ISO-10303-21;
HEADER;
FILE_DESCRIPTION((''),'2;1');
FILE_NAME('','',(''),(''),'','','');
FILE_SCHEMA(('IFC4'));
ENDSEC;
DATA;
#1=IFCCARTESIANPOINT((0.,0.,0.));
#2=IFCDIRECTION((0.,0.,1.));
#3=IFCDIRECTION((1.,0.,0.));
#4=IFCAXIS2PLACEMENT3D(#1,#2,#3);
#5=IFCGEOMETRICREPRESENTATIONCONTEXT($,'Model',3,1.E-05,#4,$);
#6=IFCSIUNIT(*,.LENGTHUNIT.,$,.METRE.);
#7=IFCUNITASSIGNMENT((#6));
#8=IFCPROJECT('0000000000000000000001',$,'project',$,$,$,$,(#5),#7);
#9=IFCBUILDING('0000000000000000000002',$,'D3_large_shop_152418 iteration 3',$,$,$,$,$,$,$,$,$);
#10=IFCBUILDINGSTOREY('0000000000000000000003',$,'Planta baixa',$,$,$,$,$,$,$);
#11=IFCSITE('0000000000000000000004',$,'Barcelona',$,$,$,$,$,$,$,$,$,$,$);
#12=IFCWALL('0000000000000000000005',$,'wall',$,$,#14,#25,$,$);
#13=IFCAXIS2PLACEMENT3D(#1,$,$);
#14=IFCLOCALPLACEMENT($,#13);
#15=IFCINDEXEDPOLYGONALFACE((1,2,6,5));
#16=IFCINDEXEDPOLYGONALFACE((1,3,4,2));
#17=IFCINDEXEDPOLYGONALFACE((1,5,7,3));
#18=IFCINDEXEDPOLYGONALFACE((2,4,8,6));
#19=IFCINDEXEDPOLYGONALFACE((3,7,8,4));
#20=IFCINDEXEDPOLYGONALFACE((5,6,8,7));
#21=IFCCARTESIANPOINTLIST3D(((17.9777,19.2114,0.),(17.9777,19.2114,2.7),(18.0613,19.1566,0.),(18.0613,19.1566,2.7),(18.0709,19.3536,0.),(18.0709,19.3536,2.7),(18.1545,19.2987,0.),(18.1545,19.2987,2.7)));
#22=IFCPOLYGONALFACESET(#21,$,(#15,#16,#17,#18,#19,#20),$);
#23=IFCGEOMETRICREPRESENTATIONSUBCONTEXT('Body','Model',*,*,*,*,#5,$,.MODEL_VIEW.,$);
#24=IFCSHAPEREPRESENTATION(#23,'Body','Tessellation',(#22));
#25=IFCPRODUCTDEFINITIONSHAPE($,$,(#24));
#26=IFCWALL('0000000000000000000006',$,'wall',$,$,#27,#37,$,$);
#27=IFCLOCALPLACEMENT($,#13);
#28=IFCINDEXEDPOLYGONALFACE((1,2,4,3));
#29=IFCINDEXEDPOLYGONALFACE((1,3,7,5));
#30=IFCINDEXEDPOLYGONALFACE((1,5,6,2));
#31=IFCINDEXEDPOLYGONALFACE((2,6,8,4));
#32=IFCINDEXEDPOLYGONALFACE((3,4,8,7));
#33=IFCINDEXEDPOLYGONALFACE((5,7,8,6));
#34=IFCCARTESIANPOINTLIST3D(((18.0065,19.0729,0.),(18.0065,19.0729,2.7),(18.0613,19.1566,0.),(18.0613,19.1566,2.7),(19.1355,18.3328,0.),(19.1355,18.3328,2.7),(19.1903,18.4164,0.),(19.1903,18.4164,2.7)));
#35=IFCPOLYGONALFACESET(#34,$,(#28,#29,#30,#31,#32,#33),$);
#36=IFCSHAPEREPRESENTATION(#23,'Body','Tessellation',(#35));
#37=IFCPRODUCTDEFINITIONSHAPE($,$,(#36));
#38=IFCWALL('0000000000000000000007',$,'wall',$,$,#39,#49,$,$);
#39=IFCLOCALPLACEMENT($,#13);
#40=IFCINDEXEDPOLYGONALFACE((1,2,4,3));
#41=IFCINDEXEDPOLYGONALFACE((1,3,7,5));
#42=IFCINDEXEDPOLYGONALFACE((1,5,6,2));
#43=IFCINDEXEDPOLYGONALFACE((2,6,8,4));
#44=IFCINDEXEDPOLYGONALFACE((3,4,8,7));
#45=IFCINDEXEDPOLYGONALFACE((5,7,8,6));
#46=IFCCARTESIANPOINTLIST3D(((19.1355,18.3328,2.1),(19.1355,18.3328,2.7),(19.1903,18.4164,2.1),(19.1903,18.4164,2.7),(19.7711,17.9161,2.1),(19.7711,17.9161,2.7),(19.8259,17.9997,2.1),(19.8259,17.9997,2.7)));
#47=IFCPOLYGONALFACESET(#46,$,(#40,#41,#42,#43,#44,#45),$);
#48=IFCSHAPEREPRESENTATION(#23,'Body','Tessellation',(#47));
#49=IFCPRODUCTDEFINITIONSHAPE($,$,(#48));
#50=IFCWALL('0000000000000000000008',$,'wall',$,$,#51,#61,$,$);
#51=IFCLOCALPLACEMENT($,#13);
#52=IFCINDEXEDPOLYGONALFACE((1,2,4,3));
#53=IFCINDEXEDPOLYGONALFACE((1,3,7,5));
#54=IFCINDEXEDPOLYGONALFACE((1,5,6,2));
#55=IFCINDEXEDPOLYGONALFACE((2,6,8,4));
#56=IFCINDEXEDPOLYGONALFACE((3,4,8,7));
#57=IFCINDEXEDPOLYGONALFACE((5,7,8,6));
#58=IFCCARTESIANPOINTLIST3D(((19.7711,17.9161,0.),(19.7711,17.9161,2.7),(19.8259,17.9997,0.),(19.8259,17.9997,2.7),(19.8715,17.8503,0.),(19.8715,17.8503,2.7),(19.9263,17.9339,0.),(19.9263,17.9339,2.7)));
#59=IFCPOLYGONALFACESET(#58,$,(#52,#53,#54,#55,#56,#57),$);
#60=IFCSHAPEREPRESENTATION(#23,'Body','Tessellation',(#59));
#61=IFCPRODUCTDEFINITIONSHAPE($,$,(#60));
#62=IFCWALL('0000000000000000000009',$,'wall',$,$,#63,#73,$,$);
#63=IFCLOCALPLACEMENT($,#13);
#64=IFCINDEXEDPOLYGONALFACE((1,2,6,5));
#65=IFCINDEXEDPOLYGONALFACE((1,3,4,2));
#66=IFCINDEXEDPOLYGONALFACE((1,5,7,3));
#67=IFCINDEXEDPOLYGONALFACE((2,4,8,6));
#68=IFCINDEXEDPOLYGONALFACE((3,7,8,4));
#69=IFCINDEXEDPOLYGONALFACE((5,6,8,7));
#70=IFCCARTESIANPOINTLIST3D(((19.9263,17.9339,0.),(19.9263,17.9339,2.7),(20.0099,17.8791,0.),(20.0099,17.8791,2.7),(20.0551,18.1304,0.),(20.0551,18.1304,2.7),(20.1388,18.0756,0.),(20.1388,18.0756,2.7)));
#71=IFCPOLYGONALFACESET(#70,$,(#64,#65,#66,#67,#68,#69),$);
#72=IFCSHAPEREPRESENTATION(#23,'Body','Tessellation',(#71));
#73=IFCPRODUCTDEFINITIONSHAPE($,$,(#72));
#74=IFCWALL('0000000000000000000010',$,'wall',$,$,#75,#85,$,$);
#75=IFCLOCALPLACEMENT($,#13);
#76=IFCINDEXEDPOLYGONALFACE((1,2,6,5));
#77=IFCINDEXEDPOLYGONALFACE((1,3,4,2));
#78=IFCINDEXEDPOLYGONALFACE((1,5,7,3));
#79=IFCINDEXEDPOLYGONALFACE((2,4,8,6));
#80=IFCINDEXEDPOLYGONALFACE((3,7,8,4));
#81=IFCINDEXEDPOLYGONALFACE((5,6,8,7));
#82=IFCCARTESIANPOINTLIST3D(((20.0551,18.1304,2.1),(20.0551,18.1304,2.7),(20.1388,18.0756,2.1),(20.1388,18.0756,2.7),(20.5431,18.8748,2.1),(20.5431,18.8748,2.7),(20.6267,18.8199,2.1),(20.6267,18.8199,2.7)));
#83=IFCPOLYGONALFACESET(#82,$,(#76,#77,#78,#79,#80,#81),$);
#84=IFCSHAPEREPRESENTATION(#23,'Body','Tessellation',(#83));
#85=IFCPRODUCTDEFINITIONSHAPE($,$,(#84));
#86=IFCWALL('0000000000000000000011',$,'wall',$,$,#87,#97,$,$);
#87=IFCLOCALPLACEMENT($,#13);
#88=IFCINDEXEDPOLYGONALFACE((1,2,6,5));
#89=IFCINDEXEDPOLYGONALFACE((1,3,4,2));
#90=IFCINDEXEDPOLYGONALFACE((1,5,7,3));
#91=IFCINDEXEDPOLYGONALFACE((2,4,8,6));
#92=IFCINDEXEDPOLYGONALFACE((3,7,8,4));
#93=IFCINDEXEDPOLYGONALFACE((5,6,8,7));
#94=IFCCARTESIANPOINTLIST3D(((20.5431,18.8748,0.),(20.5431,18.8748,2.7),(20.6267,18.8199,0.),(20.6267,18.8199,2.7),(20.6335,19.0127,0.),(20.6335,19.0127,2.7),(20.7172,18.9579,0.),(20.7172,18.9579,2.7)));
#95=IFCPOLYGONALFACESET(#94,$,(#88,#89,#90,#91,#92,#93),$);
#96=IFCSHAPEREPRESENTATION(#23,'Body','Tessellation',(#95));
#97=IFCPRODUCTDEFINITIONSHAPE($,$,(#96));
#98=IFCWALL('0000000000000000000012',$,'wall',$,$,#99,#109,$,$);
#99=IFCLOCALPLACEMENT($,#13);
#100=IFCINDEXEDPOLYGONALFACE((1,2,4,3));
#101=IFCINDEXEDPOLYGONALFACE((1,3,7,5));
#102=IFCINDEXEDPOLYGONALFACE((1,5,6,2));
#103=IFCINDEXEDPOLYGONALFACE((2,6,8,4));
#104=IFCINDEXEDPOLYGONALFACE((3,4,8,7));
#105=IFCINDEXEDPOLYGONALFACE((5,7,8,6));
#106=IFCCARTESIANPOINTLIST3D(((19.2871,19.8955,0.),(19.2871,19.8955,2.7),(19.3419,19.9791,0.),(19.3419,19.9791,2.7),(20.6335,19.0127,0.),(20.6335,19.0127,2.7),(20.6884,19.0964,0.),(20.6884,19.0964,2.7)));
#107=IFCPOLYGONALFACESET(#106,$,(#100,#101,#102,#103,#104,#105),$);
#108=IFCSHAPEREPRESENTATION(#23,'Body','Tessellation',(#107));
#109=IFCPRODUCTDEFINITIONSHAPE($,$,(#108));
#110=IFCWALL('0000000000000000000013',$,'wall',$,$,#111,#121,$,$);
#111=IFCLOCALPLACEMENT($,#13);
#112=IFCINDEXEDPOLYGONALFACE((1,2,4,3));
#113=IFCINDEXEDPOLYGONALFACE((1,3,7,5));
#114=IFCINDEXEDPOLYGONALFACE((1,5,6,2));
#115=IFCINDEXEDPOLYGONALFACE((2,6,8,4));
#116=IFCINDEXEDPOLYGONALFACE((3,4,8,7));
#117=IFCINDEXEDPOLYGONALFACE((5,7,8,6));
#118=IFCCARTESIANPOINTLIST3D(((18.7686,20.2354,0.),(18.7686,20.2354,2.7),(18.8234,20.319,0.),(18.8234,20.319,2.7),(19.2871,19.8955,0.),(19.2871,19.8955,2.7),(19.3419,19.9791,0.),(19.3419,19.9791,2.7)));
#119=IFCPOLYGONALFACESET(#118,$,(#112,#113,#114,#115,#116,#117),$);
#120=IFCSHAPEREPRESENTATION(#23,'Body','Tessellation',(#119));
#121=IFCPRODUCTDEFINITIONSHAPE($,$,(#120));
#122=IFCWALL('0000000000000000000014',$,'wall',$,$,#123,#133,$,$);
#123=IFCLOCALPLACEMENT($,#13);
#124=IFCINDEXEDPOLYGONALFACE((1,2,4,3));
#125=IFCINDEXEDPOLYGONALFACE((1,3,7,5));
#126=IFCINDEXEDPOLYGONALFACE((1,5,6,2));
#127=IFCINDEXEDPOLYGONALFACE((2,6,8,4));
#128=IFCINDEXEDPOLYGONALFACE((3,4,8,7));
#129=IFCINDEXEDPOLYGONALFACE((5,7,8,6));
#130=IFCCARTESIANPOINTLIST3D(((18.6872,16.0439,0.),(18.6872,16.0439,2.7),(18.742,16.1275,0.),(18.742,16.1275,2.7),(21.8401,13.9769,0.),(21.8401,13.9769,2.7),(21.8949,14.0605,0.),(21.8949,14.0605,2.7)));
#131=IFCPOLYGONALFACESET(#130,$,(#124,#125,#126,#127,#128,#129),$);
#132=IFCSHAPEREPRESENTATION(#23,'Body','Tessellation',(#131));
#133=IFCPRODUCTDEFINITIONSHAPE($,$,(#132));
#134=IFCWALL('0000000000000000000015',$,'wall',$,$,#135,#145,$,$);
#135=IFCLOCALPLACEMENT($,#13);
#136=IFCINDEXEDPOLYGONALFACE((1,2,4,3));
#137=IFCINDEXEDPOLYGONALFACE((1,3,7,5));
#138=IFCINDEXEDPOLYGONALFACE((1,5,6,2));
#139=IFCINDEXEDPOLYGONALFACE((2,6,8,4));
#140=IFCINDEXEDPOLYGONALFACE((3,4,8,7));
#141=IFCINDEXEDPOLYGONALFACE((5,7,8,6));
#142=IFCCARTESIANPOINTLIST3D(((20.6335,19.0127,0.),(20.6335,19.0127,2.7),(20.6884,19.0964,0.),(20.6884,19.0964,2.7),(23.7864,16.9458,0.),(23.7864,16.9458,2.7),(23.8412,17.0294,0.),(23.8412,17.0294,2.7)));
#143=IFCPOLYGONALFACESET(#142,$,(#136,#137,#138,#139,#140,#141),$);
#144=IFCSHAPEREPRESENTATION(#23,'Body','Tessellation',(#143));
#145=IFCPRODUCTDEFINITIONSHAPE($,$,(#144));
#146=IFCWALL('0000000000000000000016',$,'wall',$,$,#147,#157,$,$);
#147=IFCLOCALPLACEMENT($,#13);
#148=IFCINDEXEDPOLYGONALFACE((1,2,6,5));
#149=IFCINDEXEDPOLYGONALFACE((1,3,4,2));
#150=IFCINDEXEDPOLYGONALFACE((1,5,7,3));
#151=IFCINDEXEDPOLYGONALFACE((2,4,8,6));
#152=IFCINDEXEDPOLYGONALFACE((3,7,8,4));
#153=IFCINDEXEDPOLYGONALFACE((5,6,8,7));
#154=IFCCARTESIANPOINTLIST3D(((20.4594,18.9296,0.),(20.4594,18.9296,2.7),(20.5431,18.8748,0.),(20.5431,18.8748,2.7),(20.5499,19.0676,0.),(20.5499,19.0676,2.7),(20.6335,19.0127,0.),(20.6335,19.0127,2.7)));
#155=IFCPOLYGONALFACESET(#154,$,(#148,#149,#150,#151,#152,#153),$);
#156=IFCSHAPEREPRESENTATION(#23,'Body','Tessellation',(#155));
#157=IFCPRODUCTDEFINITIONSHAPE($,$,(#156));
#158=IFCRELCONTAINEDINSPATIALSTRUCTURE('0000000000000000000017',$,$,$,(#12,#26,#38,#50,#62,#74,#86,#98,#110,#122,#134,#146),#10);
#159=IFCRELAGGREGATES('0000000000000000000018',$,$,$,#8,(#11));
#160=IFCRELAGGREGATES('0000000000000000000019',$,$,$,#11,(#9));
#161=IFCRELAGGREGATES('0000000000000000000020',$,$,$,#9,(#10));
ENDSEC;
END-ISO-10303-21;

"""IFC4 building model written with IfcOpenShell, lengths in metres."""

from ifc_helpers import new_model, si_unit, frame, origin, origin_with_axes, place, context, subcontext, project, spatial, polyline, outline, extrude, element, save


model = new_model("IFC4")

# Units and contexts
model_context = context("Model", 3, precision=1e-05, world=origin_with_axes())
body_context = subcontext(model_context, "Body", "Model", "MODEL_VIEW")
ifc_project = project(units=[si_unit("LENGTHUNIT", "METRE")], contexts=[model_context])

# Site, building, storey
site = spatial("IfcSite", under=ifc_project, Name="Barcelona")
building = spatial("IfcBuilding", under=site, Name="D3_large_shop_152418 iteration 3")
storey = spatial("IfcBuildingStorey", under=building, Name="Planta baixa")

# Walls
wall_1_placement = place(None, origin_with_axes())
element("IfcWall", 1, at=wall_1_placement, inside=storey, Name="wall", context=body_context, shape_type="SweptSolid", body=[
    extrude(outline(polyline([(18.1545, 19.2987), (18.0613, 19.1566), (17.9777, 19.2114), (18.0709, 19.3536), (18.1545, 19.2987)])), origin(), (0.0, 0.0, 1.0), 2.7),
])
wall_2_placement = place(None, origin_with_axes())
element("IfcWall", 2, at=wall_2_placement, inside=storey, Name="wall", context=body_context, shape_type="SweptSolid", body=[
    extrude(outline(polyline([(18.0613, 19.1566), (19.1903, 18.4164), (19.1355, 18.3328), (18.0065, 19.0729), (18.0613, 19.1566)])), origin(), (0.0, 0.0, 1.0), 2.7),
])
wall_3_placement = place(None, origin_with_axes())
element("IfcWall", 3, at=wall_3_placement, inside=storey, Name="wall", context=body_context, shape_type="SweptSolid", body=[
    extrude(outline(polyline([(19.1903, 18.4164), (19.8259, 17.9997), (19.7711, 17.9161), (19.1355, 18.3328), (19.1903, 18.4164)])), frame((0.0, 0.0, 2.1)), (0.0, 0.0, 1.0), 0.6),
])
wall_4_placement = place(None, origin_with_axes())
element("IfcWall", 4, at=wall_4_placement, inside=storey, Name="wall", context=body_context, shape_type="SweptSolid", body=[
    extrude(outline(polyline([(19.8259, 17.9997), (19.9263, 17.9339), (19.8715, 17.8503), (19.7711, 17.9161), (19.8259, 17.9997)])), origin(), (0.0, 0.0, 1.0), 2.7),
])
wall_5_placement = place(None, origin_with_axes())
element("IfcWall", 5, at=wall_5_placement, inside=storey, Name="wall", context=body_context, shape_type="SweptSolid", body=[
    extrude(outline(polyline([(19.9263, 17.9339), (20.0551, 18.1304), (20.1388, 18.0756), (20.0099, 17.8791), (19.9263, 17.9339)])), origin(), (0.0, 0.0, 1.0), 2.7),
])
wall_6_placement = place(None, origin_with_axes())
element("IfcWall", 6, at=wall_6_placement, inside=storey, Name="wall", context=body_context, shape_type="SweptSolid", body=[
    extrude(outline(polyline([(20.0551, 18.1304), (20.5431, 18.8748), (20.6267, 18.8199), (20.1388, 18.0756), (20.0551, 18.1304)])), frame((0.0, 0.0, 2.1)), (0.0, 0.0, 1.0), 0.6),
])
wall_7_placement = place(None, origin_with_axes())
element("IfcWall", 7, at=wall_7_placement, inside=storey, Name="wall", context=body_context, shape_type="SweptSolid", body=[
    extrude(outline(polyline([(20.5431, 18.8748), (20.6335, 19.0127), (20.7172, 18.9579), (20.6267, 18.8199), (20.5431, 18.8748)])), origin(), (0.0, 0.0, 1.0), 2.7),
])
wall_8_placement = place(None, origin_with_axes())
element("IfcWall", 8, at=wall_8_placement, inside=storey, Name="wall", context=body_context, shape_type="SweptSolid", body=[
    extrude(outline(polyline([(20.6335, 19.0127), (19.2871, 19.8955), (19.3419, 19.9791), (20.6884, 19.0964), (20.6335, 19.0127)])), origin(), (0.0, 0.0, 1.0), 2.7),
])
wall_9_placement = place(None, origin_with_axes())
element("IfcWall", 9, at=wall_9_placement, inside=storey, Name="wall", context=body_context, shape_type="SweptSolid", body=[
    extrude(outline(polyline([(19.2871, 19.8955), (18.7686, 20.2354), (18.8234, 20.319), (19.3419, 19.9791), (19.2871, 19.8955)])), origin(), (0.0, 0.0, 1.0), 2.7),
])
wall_10_placement = place(None, origin_with_axes())
element("IfcWall", 10, at=wall_10_placement, inside=storey, Name="wall", context=body_context, shape_type="SweptSolid", body=[
    extrude(outline(polyline([(18.742, 16.1275), (21.8949, 14.0605), (21.8401, 13.9769), (18.6872, 16.0439), (18.742, 16.1275)])), origin(), (0.0, 0.0, 1.0), 2.7),
])
wall_11_placement = place(None, origin_with_axes())
element("IfcWall", 11, at=wall_11_placement, inside=storey, Name="wall", context=body_context, shape_type="SweptSolid", body=[
    extrude(outline(polyline([(23.7864, 16.9458), (20.6335, 19.0127), (20.6884, 19.0964), (23.8412, 17.0294), (23.7864, 16.9458)])), origin(), (0.0, 0.0, 1.0), 2.7),
])
wall_12_placement = place(None, origin_with_axes())
element("IfcWall", 12, at=wall_12_placement, inside=storey, Name="wall", context=body_context, shape_type="SweptSolid", body=[
    extrude(outline(polyline([(20.6335, 19.0127), (20.5431, 18.8748), (20.4594, 18.9296), (20.5499, 19.0676), (20.6335, 19.0127)])), origin(), (0.0, 0.0, 1.0), 2.7),
])

save(model, "model.ifc")
